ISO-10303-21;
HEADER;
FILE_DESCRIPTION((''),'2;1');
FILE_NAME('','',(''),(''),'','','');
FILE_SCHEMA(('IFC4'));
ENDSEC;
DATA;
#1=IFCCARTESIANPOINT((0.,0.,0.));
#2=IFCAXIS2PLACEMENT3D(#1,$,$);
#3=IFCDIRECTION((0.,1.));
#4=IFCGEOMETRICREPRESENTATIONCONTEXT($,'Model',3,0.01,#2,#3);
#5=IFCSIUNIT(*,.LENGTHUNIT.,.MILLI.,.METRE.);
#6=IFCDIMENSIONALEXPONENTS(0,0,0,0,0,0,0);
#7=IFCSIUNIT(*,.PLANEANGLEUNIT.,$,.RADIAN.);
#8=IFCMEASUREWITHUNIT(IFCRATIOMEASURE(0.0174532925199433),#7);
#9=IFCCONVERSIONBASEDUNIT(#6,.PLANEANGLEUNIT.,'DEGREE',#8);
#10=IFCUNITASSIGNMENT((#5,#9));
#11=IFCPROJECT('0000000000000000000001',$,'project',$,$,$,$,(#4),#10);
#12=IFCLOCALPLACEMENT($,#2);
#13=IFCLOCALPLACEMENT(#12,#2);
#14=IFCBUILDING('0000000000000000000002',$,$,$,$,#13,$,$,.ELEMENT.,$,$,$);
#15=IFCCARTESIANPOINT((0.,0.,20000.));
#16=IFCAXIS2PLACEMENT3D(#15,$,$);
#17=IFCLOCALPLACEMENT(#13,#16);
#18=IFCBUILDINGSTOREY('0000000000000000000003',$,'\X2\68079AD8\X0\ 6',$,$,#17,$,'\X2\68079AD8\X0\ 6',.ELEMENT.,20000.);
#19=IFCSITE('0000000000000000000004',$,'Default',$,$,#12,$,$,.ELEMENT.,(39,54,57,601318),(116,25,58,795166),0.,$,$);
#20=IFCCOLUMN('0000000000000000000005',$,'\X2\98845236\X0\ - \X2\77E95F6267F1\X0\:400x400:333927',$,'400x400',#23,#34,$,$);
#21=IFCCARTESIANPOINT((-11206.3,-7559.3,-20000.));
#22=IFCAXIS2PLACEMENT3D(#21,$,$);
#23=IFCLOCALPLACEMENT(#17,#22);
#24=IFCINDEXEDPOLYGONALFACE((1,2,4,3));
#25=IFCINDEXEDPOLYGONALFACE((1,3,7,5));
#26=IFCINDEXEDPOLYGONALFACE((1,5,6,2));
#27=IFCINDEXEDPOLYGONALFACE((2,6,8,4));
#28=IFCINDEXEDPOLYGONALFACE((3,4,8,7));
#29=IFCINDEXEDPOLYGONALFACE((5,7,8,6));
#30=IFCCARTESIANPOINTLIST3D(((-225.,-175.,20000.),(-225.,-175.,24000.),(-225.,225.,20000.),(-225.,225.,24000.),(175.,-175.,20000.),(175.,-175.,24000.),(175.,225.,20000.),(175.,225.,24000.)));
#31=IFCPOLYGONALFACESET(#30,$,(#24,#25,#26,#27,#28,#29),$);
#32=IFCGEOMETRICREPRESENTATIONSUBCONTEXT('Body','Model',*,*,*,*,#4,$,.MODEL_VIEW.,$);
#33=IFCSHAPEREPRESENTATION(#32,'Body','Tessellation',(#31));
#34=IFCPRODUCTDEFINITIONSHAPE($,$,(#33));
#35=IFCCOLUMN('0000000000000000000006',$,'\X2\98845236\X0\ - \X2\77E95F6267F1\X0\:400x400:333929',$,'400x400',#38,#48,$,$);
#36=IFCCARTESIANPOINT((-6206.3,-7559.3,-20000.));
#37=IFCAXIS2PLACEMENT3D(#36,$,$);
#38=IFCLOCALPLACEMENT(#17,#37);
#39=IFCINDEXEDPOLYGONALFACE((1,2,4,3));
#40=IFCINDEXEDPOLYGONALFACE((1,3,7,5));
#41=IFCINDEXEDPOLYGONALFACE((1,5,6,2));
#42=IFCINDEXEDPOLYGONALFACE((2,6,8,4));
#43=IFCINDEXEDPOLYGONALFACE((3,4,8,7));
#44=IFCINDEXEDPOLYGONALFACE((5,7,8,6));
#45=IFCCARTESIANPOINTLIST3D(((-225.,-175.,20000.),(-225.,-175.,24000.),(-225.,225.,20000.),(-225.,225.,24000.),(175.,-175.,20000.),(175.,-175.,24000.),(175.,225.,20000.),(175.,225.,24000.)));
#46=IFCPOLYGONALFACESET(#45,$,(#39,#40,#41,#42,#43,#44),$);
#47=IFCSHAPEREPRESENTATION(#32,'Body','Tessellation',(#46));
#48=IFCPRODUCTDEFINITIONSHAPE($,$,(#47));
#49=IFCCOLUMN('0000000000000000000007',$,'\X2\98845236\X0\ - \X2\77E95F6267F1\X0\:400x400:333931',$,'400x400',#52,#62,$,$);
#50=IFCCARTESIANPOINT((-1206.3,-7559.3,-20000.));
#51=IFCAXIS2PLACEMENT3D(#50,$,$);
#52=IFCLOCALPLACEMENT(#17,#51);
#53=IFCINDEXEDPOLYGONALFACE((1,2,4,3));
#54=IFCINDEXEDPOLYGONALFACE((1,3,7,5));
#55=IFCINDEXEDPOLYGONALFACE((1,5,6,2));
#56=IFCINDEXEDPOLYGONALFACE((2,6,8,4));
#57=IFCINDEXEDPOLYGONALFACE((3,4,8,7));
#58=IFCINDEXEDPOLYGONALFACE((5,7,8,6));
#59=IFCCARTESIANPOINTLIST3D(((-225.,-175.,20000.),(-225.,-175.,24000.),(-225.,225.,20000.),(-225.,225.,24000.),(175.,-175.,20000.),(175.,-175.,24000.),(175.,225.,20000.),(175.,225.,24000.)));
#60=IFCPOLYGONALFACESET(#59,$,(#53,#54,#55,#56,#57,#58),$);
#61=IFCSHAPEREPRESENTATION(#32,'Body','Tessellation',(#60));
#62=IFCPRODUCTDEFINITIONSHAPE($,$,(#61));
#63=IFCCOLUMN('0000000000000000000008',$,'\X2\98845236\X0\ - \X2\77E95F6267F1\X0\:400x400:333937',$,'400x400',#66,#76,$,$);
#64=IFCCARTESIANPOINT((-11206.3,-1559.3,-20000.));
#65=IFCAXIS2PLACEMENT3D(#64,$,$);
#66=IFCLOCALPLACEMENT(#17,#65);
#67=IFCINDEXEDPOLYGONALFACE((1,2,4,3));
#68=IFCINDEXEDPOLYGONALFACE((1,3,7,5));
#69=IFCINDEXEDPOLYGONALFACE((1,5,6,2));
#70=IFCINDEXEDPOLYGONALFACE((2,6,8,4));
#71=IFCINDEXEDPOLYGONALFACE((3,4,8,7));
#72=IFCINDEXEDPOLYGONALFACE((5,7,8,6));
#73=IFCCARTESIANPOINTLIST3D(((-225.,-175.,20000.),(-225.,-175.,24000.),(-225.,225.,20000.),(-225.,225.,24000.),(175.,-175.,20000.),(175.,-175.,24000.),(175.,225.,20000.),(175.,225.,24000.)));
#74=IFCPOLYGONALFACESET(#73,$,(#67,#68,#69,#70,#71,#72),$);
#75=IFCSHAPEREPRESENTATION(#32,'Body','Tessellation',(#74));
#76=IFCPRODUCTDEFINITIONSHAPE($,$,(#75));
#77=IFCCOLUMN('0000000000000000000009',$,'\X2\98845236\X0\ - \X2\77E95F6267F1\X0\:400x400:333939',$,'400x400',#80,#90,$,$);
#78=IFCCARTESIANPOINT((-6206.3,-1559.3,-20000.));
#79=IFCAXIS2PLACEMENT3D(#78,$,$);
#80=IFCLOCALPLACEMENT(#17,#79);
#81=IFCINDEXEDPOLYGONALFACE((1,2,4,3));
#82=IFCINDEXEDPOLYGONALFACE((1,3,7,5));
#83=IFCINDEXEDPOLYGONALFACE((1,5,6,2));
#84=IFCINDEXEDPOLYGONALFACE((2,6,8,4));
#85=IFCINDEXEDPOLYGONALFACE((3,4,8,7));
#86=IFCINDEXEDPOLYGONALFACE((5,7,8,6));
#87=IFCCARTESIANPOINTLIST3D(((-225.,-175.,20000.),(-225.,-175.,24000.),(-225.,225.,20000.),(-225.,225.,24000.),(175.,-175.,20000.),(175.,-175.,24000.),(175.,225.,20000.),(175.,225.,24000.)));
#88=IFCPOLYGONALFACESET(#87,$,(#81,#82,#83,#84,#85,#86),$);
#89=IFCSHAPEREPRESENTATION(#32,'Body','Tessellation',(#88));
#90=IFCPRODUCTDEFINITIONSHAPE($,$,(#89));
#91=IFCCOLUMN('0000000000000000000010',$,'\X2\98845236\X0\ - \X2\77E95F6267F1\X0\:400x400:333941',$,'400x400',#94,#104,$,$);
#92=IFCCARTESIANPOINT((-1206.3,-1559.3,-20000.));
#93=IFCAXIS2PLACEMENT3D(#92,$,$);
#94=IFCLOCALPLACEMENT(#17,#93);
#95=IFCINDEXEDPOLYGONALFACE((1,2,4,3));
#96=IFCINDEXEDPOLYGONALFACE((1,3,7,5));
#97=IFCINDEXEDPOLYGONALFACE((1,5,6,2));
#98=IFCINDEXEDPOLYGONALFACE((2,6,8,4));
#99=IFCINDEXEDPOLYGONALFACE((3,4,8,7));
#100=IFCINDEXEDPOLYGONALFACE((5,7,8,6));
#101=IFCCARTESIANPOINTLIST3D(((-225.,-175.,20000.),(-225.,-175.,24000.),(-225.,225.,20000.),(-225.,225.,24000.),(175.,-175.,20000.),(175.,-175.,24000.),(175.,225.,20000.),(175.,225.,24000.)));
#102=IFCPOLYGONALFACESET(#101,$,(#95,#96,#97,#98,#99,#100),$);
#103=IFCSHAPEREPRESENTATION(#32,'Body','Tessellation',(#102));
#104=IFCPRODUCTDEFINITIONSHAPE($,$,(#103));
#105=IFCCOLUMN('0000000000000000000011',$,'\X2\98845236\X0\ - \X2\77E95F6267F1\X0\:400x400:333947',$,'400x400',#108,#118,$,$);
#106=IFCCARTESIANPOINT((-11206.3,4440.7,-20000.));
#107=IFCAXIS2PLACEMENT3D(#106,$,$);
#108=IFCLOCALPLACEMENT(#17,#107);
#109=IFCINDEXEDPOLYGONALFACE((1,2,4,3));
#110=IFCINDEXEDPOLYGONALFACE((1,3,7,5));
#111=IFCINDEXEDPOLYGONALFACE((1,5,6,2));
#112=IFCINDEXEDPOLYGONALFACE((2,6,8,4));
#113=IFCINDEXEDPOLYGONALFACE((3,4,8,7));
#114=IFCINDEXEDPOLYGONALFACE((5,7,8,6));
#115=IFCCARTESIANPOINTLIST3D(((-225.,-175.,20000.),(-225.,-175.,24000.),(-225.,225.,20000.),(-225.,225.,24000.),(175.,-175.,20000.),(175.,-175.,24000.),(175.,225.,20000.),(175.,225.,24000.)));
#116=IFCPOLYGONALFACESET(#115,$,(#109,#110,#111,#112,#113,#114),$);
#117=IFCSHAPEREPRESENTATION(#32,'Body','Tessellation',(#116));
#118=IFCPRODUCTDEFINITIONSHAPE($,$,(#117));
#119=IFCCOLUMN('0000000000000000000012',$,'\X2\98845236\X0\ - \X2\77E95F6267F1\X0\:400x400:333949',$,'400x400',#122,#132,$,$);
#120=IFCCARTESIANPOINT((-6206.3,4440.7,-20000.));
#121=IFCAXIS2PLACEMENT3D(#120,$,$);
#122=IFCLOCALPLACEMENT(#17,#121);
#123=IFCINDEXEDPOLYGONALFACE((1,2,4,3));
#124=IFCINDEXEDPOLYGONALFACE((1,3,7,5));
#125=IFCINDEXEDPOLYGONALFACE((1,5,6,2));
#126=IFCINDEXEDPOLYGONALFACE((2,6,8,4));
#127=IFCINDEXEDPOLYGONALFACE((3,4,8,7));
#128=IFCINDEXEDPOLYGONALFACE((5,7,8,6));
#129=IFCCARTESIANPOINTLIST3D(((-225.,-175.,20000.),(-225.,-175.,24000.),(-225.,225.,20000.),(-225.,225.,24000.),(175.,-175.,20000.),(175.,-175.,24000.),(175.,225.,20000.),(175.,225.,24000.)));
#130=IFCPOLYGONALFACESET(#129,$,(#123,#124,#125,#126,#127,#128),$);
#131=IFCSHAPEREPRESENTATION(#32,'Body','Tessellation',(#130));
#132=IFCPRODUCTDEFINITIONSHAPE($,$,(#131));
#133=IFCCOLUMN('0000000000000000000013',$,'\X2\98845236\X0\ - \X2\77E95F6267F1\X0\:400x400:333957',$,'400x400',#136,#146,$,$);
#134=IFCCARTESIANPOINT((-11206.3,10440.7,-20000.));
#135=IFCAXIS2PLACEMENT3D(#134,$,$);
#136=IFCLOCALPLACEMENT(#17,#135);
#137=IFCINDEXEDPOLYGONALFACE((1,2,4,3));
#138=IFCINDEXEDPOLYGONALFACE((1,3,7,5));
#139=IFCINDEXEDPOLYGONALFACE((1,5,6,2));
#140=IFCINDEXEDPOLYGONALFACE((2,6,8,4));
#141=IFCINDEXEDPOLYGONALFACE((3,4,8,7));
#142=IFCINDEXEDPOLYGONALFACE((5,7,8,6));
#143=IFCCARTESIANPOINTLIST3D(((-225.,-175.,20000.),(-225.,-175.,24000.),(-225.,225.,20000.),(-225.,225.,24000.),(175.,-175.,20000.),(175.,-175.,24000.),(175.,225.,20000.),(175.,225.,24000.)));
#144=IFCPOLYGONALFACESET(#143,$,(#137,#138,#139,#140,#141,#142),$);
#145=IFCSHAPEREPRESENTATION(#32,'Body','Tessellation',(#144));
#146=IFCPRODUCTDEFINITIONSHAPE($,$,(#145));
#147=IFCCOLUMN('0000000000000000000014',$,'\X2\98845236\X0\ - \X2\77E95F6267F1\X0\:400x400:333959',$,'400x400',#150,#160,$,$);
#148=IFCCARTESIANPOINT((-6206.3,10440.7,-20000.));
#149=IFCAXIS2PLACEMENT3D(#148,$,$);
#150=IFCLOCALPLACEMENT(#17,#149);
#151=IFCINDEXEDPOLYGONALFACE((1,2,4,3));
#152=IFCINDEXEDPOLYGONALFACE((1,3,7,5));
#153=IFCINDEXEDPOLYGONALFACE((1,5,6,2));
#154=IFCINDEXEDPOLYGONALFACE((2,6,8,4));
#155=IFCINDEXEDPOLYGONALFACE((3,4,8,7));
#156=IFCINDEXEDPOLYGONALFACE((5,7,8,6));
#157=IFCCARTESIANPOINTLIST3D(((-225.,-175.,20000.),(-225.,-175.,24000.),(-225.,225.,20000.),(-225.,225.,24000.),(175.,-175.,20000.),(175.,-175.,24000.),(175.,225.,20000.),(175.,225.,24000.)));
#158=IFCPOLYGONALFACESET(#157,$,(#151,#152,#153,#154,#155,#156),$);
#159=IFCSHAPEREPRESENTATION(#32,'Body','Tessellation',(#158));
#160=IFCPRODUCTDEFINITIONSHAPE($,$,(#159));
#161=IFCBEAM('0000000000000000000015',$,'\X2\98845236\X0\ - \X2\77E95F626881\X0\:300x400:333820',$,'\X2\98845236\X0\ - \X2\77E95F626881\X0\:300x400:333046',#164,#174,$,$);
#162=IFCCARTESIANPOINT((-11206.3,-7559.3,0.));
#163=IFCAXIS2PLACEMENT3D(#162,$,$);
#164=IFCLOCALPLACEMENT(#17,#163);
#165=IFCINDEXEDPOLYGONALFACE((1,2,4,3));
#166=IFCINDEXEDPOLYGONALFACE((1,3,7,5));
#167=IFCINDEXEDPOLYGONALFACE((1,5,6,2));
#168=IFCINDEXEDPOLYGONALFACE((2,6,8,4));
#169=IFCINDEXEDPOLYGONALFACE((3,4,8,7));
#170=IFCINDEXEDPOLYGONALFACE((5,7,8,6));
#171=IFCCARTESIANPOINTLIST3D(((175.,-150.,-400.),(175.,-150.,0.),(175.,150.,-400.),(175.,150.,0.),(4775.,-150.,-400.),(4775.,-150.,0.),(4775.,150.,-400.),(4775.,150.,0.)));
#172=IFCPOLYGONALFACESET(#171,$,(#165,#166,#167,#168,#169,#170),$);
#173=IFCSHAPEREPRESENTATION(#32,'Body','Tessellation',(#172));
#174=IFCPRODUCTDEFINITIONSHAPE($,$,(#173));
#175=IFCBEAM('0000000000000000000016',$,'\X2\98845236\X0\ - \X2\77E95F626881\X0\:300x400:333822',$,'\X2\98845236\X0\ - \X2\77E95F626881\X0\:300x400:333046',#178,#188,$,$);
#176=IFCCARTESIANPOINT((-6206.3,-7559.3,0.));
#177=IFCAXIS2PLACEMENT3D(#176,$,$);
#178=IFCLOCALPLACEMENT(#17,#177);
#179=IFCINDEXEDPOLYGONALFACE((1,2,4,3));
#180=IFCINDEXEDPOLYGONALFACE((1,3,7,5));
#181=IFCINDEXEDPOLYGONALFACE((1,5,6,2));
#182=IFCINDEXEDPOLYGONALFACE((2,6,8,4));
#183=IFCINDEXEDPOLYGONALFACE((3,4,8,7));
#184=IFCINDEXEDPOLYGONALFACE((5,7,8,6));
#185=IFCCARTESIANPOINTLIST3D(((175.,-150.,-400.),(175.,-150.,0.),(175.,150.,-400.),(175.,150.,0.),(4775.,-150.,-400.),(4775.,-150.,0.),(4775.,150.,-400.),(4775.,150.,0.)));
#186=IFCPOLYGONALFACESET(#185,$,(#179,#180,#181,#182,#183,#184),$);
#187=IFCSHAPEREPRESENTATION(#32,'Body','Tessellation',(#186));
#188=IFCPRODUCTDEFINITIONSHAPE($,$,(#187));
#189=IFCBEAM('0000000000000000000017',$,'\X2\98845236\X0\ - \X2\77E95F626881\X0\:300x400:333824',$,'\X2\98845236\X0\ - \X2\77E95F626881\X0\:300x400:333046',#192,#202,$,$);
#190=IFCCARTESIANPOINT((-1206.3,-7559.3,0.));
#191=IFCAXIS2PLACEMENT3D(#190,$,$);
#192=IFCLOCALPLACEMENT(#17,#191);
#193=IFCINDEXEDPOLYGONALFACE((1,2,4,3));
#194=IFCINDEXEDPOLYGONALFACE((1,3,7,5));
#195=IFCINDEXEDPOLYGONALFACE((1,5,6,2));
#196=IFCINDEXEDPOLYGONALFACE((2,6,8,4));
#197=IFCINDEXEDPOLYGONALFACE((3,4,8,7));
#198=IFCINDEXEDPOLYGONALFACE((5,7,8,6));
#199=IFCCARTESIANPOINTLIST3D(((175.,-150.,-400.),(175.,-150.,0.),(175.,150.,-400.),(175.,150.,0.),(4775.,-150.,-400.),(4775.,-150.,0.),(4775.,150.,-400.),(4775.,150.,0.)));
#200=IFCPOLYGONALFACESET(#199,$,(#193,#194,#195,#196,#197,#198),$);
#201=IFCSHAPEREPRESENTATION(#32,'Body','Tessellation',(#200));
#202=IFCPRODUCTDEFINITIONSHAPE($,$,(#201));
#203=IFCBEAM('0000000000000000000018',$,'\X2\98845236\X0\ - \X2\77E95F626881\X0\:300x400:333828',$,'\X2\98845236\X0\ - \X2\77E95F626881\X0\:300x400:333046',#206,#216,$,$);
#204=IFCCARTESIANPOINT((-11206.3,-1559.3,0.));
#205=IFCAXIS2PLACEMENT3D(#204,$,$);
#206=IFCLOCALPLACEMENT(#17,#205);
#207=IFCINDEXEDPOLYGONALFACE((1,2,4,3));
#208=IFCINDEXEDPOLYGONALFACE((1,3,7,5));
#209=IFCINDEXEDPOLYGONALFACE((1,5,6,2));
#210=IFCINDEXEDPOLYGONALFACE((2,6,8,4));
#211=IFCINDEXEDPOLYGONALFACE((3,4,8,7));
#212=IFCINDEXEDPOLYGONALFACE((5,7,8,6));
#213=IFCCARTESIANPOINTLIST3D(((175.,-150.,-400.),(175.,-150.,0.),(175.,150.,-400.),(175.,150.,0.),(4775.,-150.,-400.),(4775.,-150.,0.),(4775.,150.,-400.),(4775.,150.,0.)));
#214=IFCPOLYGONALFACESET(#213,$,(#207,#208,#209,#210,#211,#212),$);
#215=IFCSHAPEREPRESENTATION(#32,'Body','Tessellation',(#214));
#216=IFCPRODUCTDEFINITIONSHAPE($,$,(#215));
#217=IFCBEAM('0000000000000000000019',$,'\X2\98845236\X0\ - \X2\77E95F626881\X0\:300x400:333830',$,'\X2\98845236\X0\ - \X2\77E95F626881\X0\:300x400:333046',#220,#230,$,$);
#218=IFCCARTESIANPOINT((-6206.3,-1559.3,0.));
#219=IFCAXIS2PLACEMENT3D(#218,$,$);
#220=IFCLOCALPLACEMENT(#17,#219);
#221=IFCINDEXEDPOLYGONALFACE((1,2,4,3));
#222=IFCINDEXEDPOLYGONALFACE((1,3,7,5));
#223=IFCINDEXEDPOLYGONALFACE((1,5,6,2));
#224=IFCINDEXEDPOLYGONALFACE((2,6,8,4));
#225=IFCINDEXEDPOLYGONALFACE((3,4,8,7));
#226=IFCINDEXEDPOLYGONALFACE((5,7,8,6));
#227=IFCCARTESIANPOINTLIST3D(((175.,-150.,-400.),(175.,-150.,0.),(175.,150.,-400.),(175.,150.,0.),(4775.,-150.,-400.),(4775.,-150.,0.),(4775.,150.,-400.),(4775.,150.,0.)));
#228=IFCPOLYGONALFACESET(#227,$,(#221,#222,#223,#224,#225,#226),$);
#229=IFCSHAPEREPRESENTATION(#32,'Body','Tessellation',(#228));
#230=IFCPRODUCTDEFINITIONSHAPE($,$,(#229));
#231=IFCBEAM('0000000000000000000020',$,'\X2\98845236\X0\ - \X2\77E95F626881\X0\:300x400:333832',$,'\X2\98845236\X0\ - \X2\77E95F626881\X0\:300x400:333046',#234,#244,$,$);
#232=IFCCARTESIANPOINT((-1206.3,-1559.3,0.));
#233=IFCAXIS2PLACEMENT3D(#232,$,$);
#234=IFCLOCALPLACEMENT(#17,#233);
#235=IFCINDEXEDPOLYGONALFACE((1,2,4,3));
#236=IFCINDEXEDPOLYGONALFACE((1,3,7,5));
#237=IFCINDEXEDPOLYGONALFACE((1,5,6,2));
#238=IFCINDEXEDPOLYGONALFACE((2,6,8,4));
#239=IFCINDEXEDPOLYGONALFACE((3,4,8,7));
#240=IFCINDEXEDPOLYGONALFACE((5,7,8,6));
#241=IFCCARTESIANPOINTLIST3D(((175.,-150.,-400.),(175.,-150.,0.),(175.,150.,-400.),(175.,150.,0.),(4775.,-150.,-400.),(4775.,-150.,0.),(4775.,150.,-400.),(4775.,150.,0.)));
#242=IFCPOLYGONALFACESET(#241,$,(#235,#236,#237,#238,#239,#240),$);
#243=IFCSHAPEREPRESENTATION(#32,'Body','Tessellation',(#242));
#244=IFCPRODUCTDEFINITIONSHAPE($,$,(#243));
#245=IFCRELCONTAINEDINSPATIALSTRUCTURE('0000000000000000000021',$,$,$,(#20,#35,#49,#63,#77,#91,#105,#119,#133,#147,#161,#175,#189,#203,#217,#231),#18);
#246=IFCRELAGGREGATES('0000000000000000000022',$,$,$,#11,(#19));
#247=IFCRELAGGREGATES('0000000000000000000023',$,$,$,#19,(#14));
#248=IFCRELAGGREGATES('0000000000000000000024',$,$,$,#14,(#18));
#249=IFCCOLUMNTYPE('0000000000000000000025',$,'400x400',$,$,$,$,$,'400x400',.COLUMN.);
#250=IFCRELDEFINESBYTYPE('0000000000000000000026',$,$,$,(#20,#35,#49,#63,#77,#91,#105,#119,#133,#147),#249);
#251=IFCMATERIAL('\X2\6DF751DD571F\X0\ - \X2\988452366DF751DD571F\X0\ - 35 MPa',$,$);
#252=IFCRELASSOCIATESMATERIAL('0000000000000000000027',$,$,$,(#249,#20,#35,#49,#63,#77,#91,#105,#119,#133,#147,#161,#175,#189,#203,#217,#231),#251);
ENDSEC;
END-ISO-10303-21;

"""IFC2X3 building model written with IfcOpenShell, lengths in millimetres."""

from ifc_helpers import new_model, entity, si_unit, converted_unit, direction, frame, frame_2d, origin, place, context, subcontext, project, spatial, rectangle, extrude, source, transform, mapped, material, type_object, type_shapes, element, save


model = new_model("IFC2X3")

# Units and contexts
model_context = context("Model", 3, precision=0.01, world=origin(), true_north=direction((0.0, 1.0)))
body_context = subcontext(model_context, "Body", "Model", "MODEL_VIEW")
ifc_project = project(units=[si_unit("LENGTHUNIT", "METRE", prefix="MILLI"), converted_unit("PLANEANGLEUNIT", "DEGREE", entity("IfcRatioMeasure", 0.0174532925199433), si_unit("PLANEANGLEUNIT", "RADIAN"), dimensions=[0, 0, 0, 0, 0, 0, 0])], contexts=[model_context])

# Site, building, storey
site_placement = place(None, origin())
site = spatial("IfcSite", under=ifc_project, at=site_placement, Name="Default", CompositionType="ELEMENT", RefLatitude=(39, 54, 57, 601318), RefLongitude=(116, 25, 58, 795166), RefElevation=0.0)
building_placement = place(site_placement, origin())
building = spatial("IfcBuilding", under=site, at=building_placement, CompositionType="ELEMENT")
storey_placement = place(building_placement, frame((0.0, 0.0, 20000.0)))
storey = spatial("IfcBuildingStorey", under=building, at=storey_placement, Name="标高 6", LongName="标高 6", CompositionType="ELEMENT", Elevation=20000.0)

# Columns
ifc_material = material(Name="混凝土 - 预制混凝土 - 35 MPa")
column_type = type_object("IfcColumnType", Name="400x400", ElementType="400x400", PredefinedType="COLUMN", material=ifc_material)
shared_shape = source(origin(), body_context, "Body", "SweptSolid", [
    extrude(rectangle(XDim=400.0, YDim=400.0, at=frame_2d((0.0, 0.0), x_axis=(1.0, 0.0))), frame((-25.0, 25.0, 20000.0)), (0.0, 0.0, 1.0), 4000.0),
])
type_shapes(column_type, [shared_shape])
for number, where, name in (
    (1, (-11206.3, -7559.3, -20000.0), "预制 - 矩形柱:400x400:333927"),
    (2, (-6206.3, -7559.3, -20000.0), "预制 - 矩形柱:400x400:333929"),
    (3, (-1206.3, -7559.3, -20000.0), "预制 - 矩形柱:400x400:333931"),
    (4, (-11206.3, -1559.3, -20000.0), "预制 - 矩形柱:400x400:333937"),
    (5, (-6206.3, -1559.3, -20000.0), "预制 - 矩形柱:400x400:333939"),
    (6, (-1206.3, -1559.3, -20000.0), "预制 - 矩形柱:400x400:333941"),
    (7, (-11206.3, 4440.7, -20000.0), "预制 - 矩形柱:400x400:333947"),
    (8, (-6206.3, 4440.7, -20000.0), "预制 - 矩形柱:400x400:333949"),
    (9, (-11206.3, 10440.7, -20000.0), "预制 - 矩形柱:400x400:333957"),
    (10, (-6206.3, 10440.7, -20000.0), "预制 - 矩形柱:400x400:333959"),
):
    element("IfcColumn", number, at=place(storey_placement, frame(where)), inside=storey, type_object=column_type, material=ifc_material, Name=name, ObjectType="400x400", context=body_context, shape_type="MappedRepresentation", body=[
        mapped(shared_shape, transform((0.0, 0.0, 0.0), scale=1.0)),
    ])

# Beams
for number, where, name in (
    (11, (-11206.3, -7559.3, 0.0), "预制 - 矩形梁:300x400:333820"),
    (12, (-6206.3, -7559.3, 0.0), "预制 - 矩形梁:300x400:333822"),
):
    element("IfcBeam", number, at=place(storey_placement, frame(where)), inside=storey, material=ifc_material, Name=name, ObjectType="预制 - 矩形梁:300x400:333046", context=body_context, shape_type="SweptSolid", body=[
        extrude(rectangle(XDim=400.0, YDim=300.0, at=frame_2d((0.0, 0.0), x_axis=(1.0, 0.0))), frame((175.0, 0.0, -200.0), z_axis=(1.0, 0.0, 0.0), x_axis=(0.0, 0.0, -1.0)), (0.0, 0.0, 1.0), 4600.0),
    ])
beam_1_placement = place(storey_placement, frame((-1206.3, -7559.3, 0.0)))
element("IfcBeam", 13, at=beam_1_placement, inside=storey, material=ifc_material, Name="预制 - 矩形梁:300x400:333824", ObjectType="预制 - 矩形梁:300x400:333046", context=body_context, shape_type="SweptSolid", body=[
    extrude(rectangle(XDim=400.0, YDim=300.0, at=frame_2d((0.0, 0.0), x_axis=(1.0, 0.0))), frame((175.0, 0.0, -200.0), z_axis=(1.0, 0.0, 0.0), x_axis=(0.0, 0.0, -1.0)), (0.0, 0.0, 1.0), 4600.0),
])
for number, where, name in (
    (14, (-11206.3, -1559.3, 0.0), "预制 - 矩形梁:300x400:333828"),
    (15, (-6206.3, -1559.3, 0.0), "预制 - 矩形梁:300x400:333830"),
    (16, (-1206.3, -1559.3, 0.0), "预制 - 矩形梁:300x400:333832"),
):
    element("IfcBeam", number, at=place(storey_placement, frame(where)), inside=storey, material=ifc_material, Name=name, ObjectType="预制 - 矩形梁:300x400:333046", context=body_context, shape_type="SweptSolid", body=[
        extrude(rectangle(XDim=400.0, YDim=300.0, at=frame_2d((0.0, 0.0), x_axis=(1.0, 0.0))), frame((175.0, 0.0, -200.0), z_axis=(1.0, 0.0, 0.0), x_axis=(0.0, 0.0, -1.0)), (0.0, 0.0, 1.0), 4600.0),
    ])

save(model, "model.ifc")
